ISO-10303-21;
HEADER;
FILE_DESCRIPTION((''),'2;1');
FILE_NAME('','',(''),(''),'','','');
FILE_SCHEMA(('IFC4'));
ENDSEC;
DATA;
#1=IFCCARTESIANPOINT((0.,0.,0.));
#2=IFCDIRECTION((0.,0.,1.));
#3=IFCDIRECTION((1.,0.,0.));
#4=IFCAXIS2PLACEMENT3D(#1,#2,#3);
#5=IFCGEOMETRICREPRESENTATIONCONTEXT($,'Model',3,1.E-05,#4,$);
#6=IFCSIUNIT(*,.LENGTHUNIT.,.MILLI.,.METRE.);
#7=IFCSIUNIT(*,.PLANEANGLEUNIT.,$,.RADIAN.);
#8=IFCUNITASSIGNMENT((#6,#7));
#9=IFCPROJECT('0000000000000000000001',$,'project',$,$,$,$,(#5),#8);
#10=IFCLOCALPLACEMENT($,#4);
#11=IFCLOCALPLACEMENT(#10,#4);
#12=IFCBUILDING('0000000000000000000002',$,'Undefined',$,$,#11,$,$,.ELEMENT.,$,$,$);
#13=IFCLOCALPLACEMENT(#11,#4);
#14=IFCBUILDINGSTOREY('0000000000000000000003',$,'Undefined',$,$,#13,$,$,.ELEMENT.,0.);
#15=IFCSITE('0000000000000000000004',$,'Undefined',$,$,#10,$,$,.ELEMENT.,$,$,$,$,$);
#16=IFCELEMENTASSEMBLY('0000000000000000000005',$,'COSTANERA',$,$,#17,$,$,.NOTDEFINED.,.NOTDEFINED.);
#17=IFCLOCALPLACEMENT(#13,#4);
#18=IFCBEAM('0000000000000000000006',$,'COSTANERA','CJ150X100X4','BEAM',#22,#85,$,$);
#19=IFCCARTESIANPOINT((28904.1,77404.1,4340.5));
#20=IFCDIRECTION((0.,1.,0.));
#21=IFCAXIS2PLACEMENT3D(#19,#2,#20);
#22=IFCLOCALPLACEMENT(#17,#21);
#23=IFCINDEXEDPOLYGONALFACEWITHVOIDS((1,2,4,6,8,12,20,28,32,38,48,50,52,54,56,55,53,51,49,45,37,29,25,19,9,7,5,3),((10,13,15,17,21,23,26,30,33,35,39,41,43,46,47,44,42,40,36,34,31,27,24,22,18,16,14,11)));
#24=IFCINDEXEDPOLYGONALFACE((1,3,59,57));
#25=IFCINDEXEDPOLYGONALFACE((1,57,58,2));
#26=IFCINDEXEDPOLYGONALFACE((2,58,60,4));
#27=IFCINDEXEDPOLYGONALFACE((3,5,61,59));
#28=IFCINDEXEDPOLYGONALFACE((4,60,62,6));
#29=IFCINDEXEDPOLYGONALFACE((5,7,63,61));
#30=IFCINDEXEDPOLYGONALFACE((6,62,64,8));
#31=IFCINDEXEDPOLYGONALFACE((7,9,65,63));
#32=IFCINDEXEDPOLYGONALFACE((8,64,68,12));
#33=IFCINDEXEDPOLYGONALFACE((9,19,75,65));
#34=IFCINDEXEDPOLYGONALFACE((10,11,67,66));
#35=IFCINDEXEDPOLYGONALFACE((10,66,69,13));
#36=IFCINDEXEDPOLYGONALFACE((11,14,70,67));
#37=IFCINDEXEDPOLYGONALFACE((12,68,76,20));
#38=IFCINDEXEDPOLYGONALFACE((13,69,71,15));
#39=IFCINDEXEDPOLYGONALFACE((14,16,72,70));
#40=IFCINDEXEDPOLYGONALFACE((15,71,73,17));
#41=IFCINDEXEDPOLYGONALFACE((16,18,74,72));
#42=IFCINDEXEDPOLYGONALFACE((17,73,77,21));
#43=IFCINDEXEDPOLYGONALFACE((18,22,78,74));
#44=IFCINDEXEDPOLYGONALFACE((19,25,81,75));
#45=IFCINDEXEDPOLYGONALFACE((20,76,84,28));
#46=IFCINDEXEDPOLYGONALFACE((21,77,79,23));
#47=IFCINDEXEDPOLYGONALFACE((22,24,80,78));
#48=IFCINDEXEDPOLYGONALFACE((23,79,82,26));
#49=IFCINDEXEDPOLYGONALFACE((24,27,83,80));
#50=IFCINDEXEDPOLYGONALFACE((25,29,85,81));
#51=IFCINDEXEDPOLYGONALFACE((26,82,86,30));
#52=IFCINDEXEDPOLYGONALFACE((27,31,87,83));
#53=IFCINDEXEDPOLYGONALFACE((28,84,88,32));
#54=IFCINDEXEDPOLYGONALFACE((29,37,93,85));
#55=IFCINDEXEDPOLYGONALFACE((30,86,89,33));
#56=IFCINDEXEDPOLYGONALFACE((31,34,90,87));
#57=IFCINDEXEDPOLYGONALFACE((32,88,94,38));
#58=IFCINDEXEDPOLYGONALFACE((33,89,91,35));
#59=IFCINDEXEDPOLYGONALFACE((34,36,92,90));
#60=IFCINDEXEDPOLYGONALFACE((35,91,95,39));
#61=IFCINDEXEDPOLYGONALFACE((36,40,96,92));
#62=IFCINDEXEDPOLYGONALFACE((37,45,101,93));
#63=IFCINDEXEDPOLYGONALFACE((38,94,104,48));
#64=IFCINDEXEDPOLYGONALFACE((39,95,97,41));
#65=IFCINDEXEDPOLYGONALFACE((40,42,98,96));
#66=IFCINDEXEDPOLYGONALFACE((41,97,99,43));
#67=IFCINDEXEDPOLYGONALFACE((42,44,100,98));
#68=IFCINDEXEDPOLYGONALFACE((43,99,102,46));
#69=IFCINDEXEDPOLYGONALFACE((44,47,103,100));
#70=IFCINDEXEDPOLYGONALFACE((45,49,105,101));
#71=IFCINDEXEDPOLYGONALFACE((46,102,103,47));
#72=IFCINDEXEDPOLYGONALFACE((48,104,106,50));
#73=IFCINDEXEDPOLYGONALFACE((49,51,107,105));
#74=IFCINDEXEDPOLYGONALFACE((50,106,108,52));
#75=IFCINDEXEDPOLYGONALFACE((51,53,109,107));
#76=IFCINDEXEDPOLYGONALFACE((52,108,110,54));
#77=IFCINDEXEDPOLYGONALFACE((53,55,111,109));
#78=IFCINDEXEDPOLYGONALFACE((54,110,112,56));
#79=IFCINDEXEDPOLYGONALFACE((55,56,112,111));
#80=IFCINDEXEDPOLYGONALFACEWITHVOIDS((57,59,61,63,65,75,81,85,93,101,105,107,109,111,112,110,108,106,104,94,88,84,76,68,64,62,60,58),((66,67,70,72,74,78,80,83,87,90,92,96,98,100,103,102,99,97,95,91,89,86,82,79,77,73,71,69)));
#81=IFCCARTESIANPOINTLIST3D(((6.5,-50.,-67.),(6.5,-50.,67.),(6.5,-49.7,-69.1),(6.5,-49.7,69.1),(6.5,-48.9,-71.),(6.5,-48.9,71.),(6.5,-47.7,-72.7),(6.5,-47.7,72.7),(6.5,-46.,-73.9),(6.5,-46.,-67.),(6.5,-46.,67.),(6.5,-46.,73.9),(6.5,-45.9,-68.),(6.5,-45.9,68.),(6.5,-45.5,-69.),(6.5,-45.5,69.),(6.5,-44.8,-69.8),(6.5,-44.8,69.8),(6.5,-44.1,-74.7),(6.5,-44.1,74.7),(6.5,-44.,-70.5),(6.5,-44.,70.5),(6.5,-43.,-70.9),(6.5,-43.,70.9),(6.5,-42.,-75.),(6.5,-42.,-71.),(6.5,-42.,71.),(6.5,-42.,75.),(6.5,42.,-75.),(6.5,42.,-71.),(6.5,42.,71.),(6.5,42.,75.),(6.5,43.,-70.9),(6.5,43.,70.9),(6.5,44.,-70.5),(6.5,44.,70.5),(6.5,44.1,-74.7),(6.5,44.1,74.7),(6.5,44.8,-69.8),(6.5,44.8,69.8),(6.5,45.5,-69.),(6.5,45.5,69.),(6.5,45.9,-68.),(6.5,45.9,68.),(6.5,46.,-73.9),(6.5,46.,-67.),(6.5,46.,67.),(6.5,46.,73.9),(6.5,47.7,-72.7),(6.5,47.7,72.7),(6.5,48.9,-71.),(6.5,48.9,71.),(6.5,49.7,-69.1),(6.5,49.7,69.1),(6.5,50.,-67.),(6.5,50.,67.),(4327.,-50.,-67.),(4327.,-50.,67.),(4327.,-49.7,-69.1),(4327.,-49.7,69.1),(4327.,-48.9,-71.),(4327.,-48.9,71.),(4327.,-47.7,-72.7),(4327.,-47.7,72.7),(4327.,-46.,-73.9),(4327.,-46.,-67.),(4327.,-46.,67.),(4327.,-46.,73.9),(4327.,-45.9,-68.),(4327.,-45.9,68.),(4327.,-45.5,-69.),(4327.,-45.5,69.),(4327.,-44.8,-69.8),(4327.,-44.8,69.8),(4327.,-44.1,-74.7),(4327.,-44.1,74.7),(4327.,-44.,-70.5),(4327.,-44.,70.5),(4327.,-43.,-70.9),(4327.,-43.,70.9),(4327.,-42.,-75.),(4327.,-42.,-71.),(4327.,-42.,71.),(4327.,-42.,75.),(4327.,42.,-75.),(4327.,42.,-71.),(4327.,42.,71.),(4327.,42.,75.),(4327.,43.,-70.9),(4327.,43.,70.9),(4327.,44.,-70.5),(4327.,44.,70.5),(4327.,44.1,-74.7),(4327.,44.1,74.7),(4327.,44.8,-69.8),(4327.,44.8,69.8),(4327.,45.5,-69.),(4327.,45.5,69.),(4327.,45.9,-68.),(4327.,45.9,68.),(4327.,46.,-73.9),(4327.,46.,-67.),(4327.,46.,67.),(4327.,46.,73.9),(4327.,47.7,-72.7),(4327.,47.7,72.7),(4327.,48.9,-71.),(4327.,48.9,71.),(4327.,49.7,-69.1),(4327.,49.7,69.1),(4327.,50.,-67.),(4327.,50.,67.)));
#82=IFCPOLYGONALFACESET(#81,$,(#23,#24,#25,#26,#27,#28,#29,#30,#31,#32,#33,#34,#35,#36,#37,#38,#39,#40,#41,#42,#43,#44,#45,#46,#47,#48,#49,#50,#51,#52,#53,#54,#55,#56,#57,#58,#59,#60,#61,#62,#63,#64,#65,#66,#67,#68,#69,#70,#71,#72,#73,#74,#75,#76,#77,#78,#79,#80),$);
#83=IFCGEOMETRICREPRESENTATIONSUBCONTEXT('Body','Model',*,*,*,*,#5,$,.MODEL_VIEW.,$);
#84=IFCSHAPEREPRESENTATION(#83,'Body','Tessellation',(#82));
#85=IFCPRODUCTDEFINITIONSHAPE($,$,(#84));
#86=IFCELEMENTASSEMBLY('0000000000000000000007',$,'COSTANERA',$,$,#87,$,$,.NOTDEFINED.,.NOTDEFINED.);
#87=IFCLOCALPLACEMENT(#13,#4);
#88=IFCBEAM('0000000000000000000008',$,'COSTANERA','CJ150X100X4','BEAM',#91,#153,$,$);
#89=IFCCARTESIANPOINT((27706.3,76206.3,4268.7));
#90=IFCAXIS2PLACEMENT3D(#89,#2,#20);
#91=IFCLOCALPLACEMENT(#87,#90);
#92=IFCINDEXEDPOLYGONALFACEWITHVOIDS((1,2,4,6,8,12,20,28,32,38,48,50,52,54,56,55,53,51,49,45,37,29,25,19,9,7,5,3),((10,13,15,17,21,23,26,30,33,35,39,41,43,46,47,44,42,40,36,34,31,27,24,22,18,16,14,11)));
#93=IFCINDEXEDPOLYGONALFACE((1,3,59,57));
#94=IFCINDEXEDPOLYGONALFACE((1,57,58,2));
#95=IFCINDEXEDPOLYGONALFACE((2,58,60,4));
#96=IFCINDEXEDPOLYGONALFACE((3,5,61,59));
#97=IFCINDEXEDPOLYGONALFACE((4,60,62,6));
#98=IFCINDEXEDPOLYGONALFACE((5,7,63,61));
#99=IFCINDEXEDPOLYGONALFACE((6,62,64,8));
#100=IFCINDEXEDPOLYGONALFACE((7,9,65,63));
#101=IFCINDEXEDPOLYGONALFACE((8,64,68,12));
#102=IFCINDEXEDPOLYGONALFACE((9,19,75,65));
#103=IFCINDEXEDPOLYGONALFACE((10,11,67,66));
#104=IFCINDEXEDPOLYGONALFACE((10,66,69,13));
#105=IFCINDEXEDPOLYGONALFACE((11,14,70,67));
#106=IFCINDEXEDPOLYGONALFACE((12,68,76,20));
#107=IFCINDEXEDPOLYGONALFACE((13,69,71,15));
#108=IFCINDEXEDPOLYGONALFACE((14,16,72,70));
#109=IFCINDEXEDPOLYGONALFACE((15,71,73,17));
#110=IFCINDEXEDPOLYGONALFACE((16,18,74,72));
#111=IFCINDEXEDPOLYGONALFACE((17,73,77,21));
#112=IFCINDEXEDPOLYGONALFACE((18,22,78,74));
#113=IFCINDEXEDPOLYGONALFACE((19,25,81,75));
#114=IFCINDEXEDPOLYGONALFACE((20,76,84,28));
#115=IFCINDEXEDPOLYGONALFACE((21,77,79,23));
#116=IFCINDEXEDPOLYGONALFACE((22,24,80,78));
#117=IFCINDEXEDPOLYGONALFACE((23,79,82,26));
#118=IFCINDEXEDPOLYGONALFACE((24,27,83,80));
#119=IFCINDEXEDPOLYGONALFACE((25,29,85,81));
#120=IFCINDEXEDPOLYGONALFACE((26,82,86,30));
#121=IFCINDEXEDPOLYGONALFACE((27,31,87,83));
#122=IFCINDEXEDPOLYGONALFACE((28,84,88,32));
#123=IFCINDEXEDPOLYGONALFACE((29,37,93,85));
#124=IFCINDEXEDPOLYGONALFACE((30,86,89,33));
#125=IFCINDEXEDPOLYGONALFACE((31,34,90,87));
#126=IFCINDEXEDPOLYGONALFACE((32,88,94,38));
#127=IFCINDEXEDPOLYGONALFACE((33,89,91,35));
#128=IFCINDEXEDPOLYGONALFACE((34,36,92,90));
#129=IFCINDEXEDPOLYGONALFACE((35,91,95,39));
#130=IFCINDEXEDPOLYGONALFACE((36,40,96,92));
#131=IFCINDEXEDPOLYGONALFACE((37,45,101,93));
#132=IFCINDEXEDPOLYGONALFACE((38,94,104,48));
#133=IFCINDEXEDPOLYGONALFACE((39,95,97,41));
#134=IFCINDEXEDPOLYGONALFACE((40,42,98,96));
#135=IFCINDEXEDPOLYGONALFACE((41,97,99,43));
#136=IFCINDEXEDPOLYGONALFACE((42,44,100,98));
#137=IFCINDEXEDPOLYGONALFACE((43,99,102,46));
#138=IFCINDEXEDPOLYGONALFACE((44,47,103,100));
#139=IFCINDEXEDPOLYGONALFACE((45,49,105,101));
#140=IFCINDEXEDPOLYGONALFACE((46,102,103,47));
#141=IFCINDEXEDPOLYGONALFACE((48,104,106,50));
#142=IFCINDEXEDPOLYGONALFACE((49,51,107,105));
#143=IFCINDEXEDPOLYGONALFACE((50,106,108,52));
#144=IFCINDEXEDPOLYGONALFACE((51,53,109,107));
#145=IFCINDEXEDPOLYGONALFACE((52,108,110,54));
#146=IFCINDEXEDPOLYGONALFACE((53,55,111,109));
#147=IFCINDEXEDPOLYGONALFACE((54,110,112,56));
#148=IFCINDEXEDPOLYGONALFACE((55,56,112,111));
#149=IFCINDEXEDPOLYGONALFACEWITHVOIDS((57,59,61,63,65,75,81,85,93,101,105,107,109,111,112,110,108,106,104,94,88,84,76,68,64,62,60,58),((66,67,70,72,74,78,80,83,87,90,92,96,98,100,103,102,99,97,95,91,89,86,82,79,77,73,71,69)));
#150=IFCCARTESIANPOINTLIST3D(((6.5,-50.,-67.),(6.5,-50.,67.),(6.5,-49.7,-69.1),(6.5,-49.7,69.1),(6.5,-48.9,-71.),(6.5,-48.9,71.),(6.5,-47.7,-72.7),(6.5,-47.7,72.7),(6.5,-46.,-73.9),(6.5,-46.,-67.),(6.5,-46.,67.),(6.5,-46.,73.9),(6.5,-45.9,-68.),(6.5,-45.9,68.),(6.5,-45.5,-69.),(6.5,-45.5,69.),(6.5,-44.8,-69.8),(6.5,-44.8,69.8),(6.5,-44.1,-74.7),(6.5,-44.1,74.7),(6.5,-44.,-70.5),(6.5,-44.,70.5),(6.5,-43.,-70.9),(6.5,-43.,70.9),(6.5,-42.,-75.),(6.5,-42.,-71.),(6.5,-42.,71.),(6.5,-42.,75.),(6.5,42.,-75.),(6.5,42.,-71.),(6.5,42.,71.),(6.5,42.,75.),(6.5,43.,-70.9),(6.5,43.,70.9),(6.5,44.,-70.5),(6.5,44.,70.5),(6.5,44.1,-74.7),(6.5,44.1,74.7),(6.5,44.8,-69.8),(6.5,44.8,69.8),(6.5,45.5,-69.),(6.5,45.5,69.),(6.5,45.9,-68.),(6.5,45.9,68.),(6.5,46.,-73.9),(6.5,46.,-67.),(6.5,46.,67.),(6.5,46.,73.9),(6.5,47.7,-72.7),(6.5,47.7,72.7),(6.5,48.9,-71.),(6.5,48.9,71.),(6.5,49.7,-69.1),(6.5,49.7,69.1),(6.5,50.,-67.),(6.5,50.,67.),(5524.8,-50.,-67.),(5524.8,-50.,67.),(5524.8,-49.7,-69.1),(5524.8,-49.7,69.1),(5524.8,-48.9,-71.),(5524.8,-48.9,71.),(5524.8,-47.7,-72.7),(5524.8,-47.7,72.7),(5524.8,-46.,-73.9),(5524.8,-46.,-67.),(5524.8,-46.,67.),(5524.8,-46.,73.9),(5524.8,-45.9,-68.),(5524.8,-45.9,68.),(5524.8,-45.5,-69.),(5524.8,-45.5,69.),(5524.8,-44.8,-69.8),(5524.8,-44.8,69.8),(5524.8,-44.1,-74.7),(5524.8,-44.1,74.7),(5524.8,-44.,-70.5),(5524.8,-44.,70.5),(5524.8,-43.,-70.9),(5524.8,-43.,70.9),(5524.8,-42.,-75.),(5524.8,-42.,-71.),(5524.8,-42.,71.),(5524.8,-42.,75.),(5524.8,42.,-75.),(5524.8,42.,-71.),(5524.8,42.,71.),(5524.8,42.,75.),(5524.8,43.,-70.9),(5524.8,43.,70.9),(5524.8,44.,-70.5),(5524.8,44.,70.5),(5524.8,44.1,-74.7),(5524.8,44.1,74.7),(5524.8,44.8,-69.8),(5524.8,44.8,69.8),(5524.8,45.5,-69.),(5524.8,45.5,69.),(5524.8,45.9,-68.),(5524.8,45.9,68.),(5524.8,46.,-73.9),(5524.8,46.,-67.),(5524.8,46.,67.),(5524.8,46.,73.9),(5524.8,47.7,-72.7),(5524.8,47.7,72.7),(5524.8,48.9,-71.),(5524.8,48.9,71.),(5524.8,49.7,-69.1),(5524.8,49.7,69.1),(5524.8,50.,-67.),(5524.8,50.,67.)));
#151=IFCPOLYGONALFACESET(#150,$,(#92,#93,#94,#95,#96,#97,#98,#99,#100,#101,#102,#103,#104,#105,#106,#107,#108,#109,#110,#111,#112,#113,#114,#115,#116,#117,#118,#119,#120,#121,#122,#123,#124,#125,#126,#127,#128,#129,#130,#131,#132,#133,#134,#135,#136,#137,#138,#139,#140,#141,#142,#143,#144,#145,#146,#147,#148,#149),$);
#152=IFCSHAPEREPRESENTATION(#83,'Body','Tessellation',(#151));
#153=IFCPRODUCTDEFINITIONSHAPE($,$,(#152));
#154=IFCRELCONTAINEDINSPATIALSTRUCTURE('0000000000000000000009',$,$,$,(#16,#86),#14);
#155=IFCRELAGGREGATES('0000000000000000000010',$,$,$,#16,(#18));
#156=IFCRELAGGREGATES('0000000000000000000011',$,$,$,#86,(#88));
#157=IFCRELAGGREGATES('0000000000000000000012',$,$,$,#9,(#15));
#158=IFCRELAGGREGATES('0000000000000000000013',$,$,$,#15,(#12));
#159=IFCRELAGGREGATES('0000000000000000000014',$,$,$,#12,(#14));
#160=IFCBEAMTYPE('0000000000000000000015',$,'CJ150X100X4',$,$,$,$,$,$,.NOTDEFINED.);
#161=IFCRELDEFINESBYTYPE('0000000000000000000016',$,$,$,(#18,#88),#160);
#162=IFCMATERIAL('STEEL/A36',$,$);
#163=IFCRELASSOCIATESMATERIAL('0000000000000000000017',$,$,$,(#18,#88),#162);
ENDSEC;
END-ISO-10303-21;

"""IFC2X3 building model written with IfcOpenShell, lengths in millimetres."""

from ifc_helpers import new_model, si_unit, frame, origin_with_axes, origin_2d_with_axis, place, context, subcontext, project, spatial, hollow_rectangle, extrude, clip, halfspace, material, type_object, element, aggregate, save


model = new_model("IFC2X3")

# Units and contexts
model_context = context("Model", 3, precision=1e-05, world=origin_with_axes())
body_context = subcontext(model_context, "Body", "Model", "MODEL_VIEW")
ifc_project = project(units=[si_unit("LENGTHUNIT", "METRE", prefix="MILLI"), si_unit("PLANEANGLEUNIT", "RADIAN")], contexts=[model_context])

# Site, building, storey
site_placement = place(None, origin_with_axes())
site = spatial("IfcSite", under=ifc_project, at=site_placement, Name="Undefined", CompositionType="ELEMENT")
building_placement = place(site_placement, origin_with_axes())
building = spatial("IfcBuilding", under=site, at=building_placement, Name="Undefined", CompositionType="ELEMENT")
storey_placement = place(building_placement, origin_with_axes())
storey = spatial("IfcBuildingStorey", under=building, at=storey_placement, Name="Undefined", CompositionType="ELEMENT", Elevation=0.0)

# Element assemblies, beams
assembly_1_placement = place(storey_placement, origin_with_axes())
assembly_1 = element("IfcElementAssembly", 1, at=assembly_1_placement, inside=storey, Name="COSTANERA", AssemblyPlace="NOTDEFINED", PredefinedType="NOTDEFINED")
ifc_material_1 = material(Name="STEEL/A36")
beam_type = type_object("IfcBeamType", Name="CJ150X100X4", PredefinedType="NOTDEFINED")
beam_1_placement = place(assembly_1_placement, frame((28904.1, 77404.1, 4340.5), z_axis=(0.0, 0.0, 1.0), x_axis=(0.0, 1.0, 0.0)))
beam_1 = element("IfcBeam", 2, at=beam_1_placement, type_object=beam_type, material=ifc_material_1, Name="COSTANERA", Description="CJ150X100X4", ObjectType="BEAM", context=body_context, shape_type="Clipping", body=[
    clip(extrude(hollow_rectangle(XDim=100.0, YDim=150.0, WallThickness=4.0, InnerFilletRadius=4.0, OuterFilletRadius=8.0, at=origin_2d_with_axis()), frame((4327.0, 0.0, 0.0), z_axis=(-1.0, 0.0, 0.0), x_axis=(0.0, -1.0, 0.0)), (0.0, 0.0, 1.0), 4327.0), halfspace(frame((6.5, 0.0, -1000.0), z_axis=(1.0, 0.0, 0.0), x_axis=(0.0, -1.0, 0.0)), True)),
])
assembly_2_placement = place(storey_placement, origin_with_axes())
assembly_2 = element("IfcElementAssembly", 3, at=assembly_2_placement, inside=storey, Name="COSTANERA", AssemblyPlace="NOTDEFINED", PredefinedType="NOTDEFINED")
beam_2_placement = place(assembly_2_placement, frame((27706.3, 76206.3, 4268.7), z_axis=(0.0, 0.0, 1.0), x_axis=(0.0, 1.0, 0.0)))
beam_2 = element("IfcBeam", 4, at=beam_2_placement, type_object=beam_type, material=ifc_material_1, Name="COSTANERA", Description="CJ150X100X4", ObjectType="BEAM", context=body_context, shape_type="Clipping", body=[
    clip(extrude(hollow_rectangle(XDim=100.0, YDim=150.0, WallThickness=4.0, InnerFilletRadius=4.0, OuterFilletRadius=8.0, at=origin_2d_with_axis()), frame((5524.8, 0.0, 0.0), z_axis=(-1.0, 0.0, 0.0), x_axis=(0.0, -1.0, 0.0)), (0.0, 0.0, 1.0), 5524.8), halfspace(frame((6.5, 0.0, -1000.0), z_axis=(1.0, 0.0, 0.0), x_axis=(0.0, -1.0, 0.0)), True)),
])

aggregate(assembly_1, [beam_1])

aggregate(assembly_2, [beam_2])

save(model, "model.ifc")
